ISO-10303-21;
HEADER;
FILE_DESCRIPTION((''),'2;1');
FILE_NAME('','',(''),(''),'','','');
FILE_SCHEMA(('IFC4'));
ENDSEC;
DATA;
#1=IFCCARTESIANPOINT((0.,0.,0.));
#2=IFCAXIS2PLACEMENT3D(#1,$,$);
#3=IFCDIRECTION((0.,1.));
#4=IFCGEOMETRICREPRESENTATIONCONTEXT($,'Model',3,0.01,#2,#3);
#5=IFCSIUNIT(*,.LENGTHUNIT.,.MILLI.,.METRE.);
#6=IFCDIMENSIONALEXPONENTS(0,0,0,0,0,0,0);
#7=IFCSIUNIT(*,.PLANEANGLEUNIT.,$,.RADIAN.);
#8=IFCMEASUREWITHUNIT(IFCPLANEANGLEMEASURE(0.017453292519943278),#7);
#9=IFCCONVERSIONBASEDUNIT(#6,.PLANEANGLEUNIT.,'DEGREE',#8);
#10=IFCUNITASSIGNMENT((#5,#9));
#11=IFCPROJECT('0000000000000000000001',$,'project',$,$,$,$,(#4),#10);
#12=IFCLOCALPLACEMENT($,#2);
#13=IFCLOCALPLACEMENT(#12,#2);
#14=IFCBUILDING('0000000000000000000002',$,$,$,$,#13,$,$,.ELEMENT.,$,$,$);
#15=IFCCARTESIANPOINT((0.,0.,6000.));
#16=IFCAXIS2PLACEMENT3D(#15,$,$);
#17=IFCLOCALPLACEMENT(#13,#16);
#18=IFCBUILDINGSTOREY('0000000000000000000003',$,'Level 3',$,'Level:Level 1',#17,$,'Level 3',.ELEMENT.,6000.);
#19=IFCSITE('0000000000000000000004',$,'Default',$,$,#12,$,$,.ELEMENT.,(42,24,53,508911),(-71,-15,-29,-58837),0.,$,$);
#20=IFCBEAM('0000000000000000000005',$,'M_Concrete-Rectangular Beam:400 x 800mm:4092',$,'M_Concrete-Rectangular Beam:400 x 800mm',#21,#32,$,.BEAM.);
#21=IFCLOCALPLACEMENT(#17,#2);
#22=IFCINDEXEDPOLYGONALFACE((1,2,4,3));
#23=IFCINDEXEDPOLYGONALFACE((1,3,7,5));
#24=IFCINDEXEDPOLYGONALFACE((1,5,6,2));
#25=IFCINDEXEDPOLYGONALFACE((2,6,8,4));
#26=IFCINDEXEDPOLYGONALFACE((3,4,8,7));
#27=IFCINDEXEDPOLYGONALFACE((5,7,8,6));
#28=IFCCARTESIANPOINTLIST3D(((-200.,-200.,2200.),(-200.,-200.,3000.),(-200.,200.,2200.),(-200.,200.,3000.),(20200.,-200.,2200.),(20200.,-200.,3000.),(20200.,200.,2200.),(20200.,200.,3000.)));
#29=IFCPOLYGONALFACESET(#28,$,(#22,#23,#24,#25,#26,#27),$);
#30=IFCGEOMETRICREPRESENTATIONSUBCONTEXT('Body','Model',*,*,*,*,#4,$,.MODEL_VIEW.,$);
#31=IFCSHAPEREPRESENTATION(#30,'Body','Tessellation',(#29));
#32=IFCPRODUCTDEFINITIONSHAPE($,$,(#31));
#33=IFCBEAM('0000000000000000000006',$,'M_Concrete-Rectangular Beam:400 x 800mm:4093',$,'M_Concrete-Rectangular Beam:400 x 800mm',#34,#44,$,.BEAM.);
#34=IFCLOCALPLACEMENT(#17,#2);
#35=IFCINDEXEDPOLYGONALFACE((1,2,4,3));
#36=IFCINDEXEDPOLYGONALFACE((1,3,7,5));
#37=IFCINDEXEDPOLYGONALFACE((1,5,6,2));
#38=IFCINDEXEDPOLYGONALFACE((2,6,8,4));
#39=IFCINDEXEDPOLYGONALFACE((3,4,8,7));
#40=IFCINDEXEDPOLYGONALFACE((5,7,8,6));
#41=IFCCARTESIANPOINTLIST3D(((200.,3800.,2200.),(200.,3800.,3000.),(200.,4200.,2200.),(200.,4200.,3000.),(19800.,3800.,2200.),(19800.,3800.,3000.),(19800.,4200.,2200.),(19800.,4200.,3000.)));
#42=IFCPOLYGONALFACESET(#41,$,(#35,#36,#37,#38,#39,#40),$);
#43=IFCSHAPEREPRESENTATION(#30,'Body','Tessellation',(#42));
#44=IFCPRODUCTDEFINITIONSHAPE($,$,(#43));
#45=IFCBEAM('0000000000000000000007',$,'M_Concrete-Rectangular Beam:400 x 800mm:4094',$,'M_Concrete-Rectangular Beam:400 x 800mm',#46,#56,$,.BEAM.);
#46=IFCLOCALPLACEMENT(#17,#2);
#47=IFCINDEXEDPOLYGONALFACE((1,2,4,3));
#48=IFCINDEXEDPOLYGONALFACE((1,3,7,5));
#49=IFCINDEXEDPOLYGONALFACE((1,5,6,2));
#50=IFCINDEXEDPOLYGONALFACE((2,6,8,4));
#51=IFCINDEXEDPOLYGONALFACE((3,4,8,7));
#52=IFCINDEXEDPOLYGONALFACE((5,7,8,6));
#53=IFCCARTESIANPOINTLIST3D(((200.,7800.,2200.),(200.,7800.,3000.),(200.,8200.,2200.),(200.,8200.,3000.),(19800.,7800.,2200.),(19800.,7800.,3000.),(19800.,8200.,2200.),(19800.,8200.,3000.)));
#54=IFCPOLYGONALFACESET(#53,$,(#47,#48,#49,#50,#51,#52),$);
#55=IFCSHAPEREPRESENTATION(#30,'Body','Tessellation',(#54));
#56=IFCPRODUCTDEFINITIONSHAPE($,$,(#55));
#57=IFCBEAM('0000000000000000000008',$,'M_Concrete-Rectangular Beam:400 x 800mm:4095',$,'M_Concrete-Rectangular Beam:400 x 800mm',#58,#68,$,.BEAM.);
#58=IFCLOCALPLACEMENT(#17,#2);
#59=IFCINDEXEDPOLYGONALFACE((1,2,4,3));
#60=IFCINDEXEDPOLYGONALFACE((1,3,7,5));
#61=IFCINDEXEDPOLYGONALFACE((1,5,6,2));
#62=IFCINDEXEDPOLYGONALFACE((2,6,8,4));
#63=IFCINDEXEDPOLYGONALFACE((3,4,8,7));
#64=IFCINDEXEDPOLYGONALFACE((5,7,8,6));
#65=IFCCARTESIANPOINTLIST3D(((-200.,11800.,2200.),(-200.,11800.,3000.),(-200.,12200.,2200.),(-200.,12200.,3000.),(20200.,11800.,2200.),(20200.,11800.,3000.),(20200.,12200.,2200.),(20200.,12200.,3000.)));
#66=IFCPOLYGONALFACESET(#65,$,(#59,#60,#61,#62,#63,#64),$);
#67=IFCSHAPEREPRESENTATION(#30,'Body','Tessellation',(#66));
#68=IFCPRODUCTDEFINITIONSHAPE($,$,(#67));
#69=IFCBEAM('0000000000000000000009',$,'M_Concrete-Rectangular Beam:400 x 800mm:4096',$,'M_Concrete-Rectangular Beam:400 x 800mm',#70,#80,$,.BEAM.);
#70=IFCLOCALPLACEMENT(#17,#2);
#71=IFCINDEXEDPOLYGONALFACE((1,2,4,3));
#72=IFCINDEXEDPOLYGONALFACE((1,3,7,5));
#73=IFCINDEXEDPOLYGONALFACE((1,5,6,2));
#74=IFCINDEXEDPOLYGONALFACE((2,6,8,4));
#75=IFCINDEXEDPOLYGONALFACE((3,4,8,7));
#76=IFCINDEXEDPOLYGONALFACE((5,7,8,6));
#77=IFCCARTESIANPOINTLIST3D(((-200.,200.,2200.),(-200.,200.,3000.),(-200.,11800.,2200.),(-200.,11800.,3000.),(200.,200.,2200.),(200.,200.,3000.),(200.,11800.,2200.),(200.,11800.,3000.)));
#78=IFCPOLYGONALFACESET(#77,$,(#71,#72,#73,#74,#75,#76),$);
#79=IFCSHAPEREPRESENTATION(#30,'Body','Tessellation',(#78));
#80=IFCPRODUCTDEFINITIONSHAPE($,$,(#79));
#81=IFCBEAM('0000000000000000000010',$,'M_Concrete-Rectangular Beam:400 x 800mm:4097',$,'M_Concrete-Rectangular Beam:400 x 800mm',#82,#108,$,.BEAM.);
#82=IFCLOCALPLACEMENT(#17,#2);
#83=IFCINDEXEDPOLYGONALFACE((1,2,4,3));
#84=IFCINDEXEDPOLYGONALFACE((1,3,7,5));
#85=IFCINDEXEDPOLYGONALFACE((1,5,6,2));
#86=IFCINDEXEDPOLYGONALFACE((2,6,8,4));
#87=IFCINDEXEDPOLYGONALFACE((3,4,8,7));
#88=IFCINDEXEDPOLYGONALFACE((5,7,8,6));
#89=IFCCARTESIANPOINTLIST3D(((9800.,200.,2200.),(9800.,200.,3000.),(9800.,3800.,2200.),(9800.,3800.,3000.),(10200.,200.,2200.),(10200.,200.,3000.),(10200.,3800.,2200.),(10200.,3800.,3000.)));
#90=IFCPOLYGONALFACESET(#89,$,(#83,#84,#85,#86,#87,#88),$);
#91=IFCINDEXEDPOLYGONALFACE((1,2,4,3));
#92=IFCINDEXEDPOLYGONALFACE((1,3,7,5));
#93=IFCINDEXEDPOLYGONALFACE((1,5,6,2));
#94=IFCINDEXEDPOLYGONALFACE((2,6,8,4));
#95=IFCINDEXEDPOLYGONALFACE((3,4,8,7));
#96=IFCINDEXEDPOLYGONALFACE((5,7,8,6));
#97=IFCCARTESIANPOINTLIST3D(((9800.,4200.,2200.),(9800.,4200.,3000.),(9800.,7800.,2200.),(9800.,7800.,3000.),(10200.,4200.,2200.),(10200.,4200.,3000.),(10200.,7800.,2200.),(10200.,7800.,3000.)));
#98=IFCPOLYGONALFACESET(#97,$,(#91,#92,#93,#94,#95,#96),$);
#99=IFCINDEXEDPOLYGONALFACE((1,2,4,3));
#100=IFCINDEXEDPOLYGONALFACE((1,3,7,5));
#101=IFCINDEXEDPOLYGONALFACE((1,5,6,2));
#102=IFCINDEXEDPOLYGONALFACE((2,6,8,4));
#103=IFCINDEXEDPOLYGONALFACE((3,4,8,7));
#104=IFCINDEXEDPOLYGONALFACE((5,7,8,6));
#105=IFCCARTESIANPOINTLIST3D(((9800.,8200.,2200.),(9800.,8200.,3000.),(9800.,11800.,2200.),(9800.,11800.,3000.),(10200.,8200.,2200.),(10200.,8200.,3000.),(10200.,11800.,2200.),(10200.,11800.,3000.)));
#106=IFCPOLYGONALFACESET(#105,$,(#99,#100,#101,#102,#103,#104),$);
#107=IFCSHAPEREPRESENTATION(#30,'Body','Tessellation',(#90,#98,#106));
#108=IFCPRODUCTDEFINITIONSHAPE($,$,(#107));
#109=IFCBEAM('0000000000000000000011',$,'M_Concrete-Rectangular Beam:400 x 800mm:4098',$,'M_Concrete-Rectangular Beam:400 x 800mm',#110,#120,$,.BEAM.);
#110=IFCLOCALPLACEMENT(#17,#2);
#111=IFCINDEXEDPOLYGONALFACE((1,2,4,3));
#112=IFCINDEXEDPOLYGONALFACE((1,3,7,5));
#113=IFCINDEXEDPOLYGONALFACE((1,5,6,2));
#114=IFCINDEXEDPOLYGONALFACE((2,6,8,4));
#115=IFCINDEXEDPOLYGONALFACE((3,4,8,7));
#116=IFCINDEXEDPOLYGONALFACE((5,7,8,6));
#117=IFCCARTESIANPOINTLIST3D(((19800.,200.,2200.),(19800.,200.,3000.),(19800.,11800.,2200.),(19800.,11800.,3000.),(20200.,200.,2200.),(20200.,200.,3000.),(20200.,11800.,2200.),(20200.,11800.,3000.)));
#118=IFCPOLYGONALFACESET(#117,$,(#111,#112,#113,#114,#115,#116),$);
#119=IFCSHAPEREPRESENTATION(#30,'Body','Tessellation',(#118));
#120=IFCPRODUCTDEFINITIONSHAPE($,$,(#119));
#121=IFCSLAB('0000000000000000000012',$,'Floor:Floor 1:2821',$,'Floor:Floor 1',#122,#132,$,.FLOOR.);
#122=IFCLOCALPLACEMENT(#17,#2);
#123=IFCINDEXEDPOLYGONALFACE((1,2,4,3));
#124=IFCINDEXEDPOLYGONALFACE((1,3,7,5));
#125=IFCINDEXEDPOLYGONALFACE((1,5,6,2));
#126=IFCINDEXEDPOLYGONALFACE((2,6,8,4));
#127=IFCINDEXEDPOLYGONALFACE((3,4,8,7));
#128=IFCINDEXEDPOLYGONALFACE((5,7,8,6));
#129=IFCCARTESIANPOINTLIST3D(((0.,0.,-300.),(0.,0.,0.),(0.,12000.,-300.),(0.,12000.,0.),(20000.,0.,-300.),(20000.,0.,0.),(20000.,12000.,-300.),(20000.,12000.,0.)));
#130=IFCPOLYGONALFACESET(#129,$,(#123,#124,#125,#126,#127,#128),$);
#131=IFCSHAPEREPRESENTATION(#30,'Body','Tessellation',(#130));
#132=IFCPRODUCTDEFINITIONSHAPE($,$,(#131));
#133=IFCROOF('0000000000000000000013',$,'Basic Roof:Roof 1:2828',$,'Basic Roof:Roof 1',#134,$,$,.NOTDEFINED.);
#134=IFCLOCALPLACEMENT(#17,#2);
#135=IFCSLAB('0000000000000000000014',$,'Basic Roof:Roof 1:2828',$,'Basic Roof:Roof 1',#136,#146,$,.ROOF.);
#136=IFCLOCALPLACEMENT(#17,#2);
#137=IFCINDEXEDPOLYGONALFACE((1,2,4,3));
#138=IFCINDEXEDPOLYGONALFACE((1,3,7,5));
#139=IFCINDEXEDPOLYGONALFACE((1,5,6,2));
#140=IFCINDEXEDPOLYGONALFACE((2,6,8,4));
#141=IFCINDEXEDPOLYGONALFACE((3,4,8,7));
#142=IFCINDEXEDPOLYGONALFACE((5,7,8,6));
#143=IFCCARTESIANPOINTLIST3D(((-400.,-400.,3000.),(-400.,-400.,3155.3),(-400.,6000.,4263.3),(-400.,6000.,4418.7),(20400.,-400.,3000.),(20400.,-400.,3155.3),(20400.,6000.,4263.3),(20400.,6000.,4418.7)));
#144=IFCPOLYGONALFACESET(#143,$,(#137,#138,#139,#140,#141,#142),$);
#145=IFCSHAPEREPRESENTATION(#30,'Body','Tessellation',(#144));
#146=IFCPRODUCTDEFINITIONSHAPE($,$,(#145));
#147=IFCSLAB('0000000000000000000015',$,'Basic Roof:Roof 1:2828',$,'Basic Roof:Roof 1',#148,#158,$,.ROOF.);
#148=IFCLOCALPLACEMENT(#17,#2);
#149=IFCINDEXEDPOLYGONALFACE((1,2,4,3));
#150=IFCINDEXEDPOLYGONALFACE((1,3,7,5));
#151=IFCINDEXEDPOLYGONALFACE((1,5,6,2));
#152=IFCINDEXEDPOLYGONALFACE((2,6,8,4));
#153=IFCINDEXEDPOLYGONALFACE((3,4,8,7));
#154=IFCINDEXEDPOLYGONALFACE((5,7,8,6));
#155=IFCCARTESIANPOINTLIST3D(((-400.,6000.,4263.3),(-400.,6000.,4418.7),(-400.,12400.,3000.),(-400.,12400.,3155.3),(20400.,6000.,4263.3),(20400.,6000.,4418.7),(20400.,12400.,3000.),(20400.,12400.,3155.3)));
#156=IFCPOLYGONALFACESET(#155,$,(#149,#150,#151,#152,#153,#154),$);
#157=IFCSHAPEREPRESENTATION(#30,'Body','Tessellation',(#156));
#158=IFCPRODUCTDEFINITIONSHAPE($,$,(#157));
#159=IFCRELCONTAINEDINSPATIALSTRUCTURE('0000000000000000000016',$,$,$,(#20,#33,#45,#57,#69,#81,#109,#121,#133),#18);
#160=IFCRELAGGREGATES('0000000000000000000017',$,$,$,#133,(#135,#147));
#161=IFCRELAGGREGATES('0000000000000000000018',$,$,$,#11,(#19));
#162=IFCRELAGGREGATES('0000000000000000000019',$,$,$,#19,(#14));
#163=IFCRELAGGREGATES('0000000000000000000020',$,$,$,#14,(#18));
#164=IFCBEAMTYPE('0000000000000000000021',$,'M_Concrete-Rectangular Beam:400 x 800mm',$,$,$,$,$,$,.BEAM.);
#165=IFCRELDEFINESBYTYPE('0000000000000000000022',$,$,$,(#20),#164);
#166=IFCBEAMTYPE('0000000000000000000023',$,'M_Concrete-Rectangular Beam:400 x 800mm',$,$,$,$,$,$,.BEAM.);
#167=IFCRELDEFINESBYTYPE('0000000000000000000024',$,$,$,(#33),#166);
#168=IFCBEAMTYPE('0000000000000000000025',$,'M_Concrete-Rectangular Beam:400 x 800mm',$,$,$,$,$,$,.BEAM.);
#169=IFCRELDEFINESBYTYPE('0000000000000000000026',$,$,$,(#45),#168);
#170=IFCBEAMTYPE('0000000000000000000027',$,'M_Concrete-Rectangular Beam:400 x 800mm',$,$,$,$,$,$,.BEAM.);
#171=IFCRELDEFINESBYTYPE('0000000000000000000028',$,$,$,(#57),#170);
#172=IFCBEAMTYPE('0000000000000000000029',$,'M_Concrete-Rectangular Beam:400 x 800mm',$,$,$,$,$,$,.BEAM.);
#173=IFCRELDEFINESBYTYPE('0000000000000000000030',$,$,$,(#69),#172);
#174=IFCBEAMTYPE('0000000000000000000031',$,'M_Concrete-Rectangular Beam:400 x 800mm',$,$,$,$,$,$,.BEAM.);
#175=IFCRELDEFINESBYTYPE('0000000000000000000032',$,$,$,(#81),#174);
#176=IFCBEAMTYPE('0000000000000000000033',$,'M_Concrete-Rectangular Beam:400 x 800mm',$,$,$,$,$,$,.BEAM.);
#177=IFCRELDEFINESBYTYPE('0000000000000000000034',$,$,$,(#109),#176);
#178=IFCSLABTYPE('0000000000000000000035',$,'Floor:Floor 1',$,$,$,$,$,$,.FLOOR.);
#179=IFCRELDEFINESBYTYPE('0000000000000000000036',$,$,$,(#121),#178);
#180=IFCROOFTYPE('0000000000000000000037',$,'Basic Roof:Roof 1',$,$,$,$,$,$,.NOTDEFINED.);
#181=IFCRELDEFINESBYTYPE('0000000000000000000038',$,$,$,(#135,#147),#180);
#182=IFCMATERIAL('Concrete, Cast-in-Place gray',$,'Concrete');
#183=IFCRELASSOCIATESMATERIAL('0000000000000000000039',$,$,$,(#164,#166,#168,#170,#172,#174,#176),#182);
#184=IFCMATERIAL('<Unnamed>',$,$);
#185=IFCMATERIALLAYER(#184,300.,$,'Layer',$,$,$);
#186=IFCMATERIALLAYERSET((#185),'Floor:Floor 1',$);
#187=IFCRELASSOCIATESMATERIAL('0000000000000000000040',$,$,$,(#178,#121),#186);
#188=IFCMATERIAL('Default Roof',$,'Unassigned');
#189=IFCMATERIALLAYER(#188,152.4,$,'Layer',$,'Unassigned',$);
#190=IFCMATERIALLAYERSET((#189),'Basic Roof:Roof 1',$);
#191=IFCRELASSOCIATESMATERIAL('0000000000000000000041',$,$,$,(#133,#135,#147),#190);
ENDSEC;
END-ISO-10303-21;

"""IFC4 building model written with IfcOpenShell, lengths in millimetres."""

from ifc_helpers import new_model, entity, si_unit, converted_unit, direction, frame, frame_2d, origin, origin_2d_with_axis, place, context, subcontext, project, spatial, rectangle, extrude, source, transform, mapped, material, layer, layer_set, layer_usage, material_profile, profile_set, type_object, type_shapes, element, aggregate, save


model = new_model("IFC4")

# Units and contexts
model_context = context("Model", 3, precision=0.01, world=origin(), true_north=direction((0.0, 1.0)))
body_context = subcontext(model_context, "Body", "Model", "MODEL_VIEW")
ifc_project = project(units=[si_unit("LENGTHUNIT", "METRE", prefix="MILLI"), converted_unit("PLANEANGLEUNIT", "DEGREE", entity("IfcPlaneAngleMeasure", 0.017453292519943278), si_unit("PLANEANGLEUNIT", "RADIAN"), dimensions=[0, 0, 0, 0, 0, 0, 0])], contexts=[model_context])

# Site, building, storey
site_placement = place(None, origin())
site = spatial("IfcSite", under=ifc_project, at=site_placement, Name="Default", CompositionType="ELEMENT", RefLatitude=(42, 24, 53, 508911), RefLongitude=(-71, -15, -29, -58837), RefElevation=0.0)
building_placement = place(site_placement, origin())
building = spatial("IfcBuilding", under=site, at=building_placement, CompositionType="ELEMENT")
storey_placement = place(building_placement, frame((0.0, 0.0, 6000.0)))
storey = spatial("IfcBuildingStorey", under=building, at=storey_placement, Name="Level 3", ObjectType="Level:Level 1", LongName="Level 3", CompositionType="ELEMENT", Elevation=6000.0)

# Beams
ifc_material_1 = material(Name="Concrete, Cast-in-Place gray", Category="Concrete")
ifc_material_profile = material_profile(ifc_material_1, rectangle(XDim=800.0, YDim=400.0, at=origin_2d_with_axis()), Name="400 x 800mm")
ifc_profile_set = profile_set([ifc_material_profile], Name="400 x 800mm")
beam_type_1 = type_object("IfcBeamType", Name="M_Concrete-Rectangular Beam:400 x 800mm", PredefinedType="BEAM", material=ifc_profile_set)
shared_shape_1 = source(origin(), body_context, "Body", "SweptSolid", [
    extrude(rectangle(XDim=800.0, YDim=400.0, at=origin_2d_with_axis()), frame((-200.0, 0.0, 8600.0), z_axis=(1.0, 0.0, 0.0), x_axis=(0.0, 0.0, -1.0)), (0.0, 0.0, 1.0), 20400.0),
])
type_shapes(beam_type_1, [shared_shape_1])
beam_1_placement = place(storey_placement, frame((0.0, 0.0, -6000.0)))
element("IfcBeam", 1, at=beam_1_placement, inside=storey, type_object=beam_type_1, Name="M_Concrete-Rectangular Beam:400 x 800mm:4092", ObjectType="M_Concrete-Rectangular Beam:400 x 800mm", PredefinedType="BEAM", context=body_context, shape_type="MappedRepresentation", body=[
    mapped(shared_shape_1, transform((0.0, 0.0, 0.0), scale=1.0)),
])
beam_type_2 = type_object("IfcBeamType", Name="M_Concrete-Rectangular Beam:400 x 800mm", PredefinedType="BEAM", material=ifc_profile_set)
shared_shape_2 = source(origin(), body_context, "Body", "SweptSolid", [
    extrude(rectangle(XDim=800.0, YDim=400.0, at=origin_2d_with_axis()), frame((200.0, 4000.0, 8600.0), z_axis=(1.0, 0.0, 0.0), x_axis=(0.0, 0.0, -1.0)), (0.0, 0.0, 1.0), 19600.0),
])
type_shapes(beam_type_2, [shared_shape_2])
beam_2_placement = place(storey_placement, frame((0.0, 0.0, -6000.0)))
element("IfcBeam", 2, at=beam_2_placement, inside=storey, type_object=beam_type_2, Name="M_Concrete-Rectangular Beam:400 x 800mm:4093", ObjectType="M_Concrete-Rectangular Beam:400 x 800mm", PredefinedType="BEAM", context=body_context, shape_type="MappedRepresentation", body=[
    mapped(shared_shape_2, transform((0.0, 0.0, 0.0), scale=1.0)),
])
beam_type_3 = type_object("IfcBeamType", Name="M_Concrete-Rectangular Beam:400 x 800mm", PredefinedType="BEAM", material=ifc_profile_set)
shared_shape_3 = source(origin(), body_context, "Body", "SweptSolid", [
    extrude(rectangle(XDim=800.0, YDim=400.0, at=frame_2d((0.0, 0.0), x_axis=(1.0, 0.0))), frame((200.0, 8000.0, 8600.0), z_axis=(1.0, 0.0, 0.0), x_axis=(0.0, 0.0, -1.0)), (0.0, 0.0, 1.0), 19600.0),
])
type_shapes(beam_type_3, [shared_shape_3])
beam_3_placement = place(storey_placement, frame((0.0, 0.0, -6000.0)))
element("IfcBeam", 3, at=beam_3_placement, inside=storey, type_object=beam_type_3, Name="M_Concrete-Rectangular Beam:400 x 800mm:4094", ObjectType="M_Concrete-Rectangular Beam:400 x 800mm", PredefinedType="BEAM", context=body_context, shape_type="MappedRepresentation", body=[
    mapped(shared_shape_3, transform((0.0, 0.0, 0.0), scale=1.0)),
])
beam_type_4 = type_object("IfcBeamType", Name="M_Concrete-Rectangular Beam:400 x 800mm", PredefinedType="BEAM", material=ifc_profile_set)
shared_shape_4 = source(origin(), body_context, "Body", "SweptSolid", [
    extrude(rectangle(XDim=800.0, YDim=400.0, at=frame_2d((0.0, 0.0), x_axis=(1.0, 0.0))), frame((-200.0, 12000.0, 8600.0), z_axis=(1.0, 0.0, 0.0), x_axis=(0.0, 0.0, -1.0)), (0.0, 0.0, 1.0), 20400.0),
])
type_shapes(beam_type_4, [shared_shape_4])
beam_4_placement = place(storey_placement, frame((0.0, 0.0, -6000.0)))
element("IfcBeam", 4, at=beam_4_placement, inside=storey, type_object=beam_type_4, Name="M_Concrete-Rectangular Beam:400 x 800mm:4095", ObjectType="M_Concrete-Rectangular Beam:400 x 800mm", PredefinedType="BEAM", context=body_context, shape_type="MappedRepresentation", body=[
    mapped(shared_shape_4, transform((0.0, 0.0, 0.0), scale=1.0)),
])
beam_type_5 = type_object("IfcBeamType", Name="M_Concrete-Rectangular Beam:400 x 800mm", PredefinedType="BEAM", material=ifc_profile_set)
shared_shape_5 = source(origin(), body_context, "Body", "SweptSolid", [
    extrude(rectangle(XDim=800.0, YDim=400.0, at=frame_2d((0.0, 0.0), x_axis=(0.0, 1.0))), frame((0.0, 200.0, 8600.0), z_axis=(0.0, 1.0, 0.0), x_axis=(-1.0, 0.0, 0.0)), (0.0, 0.0, 1.0), 11600.0),
])
type_shapes(beam_type_5, [shared_shape_5])
beam_5_placement = place(storey_placement, frame((0.0, 0.0, -6000.0)))
element("IfcBeam", 5, at=beam_5_placement, inside=storey, type_object=beam_type_5, Name="M_Concrete-Rectangular Beam:400 x 800mm:4096", ObjectType="M_Concrete-Rectangular Beam:400 x 800mm", PredefinedType="BEAM", context=body_context, shape_type="MappedRepresentation", body=[
    mapped(shared_shape_5, transform((0.0, 0.0, 0.0), scale=1.0)),
])
beam_type_6 = type_object("IfcBeamType", Name="M_Concrete-Rectangular Beam:400 x 800mm", PredefinedType="BEAM", material=ifc_profile_set)
shared_shape_6 = source(origin(), body_context, "Body", "SweptSolid", [
    extrude(rectangle(XDim=800.0, YDim=400.0, at=frame_2d((0.0, 0.0), x_axis=(0.0, 1.0))), frame((10000.0, 200.0, 8600.0), z_axis=(0.0, 1.0, 0.0), x_axis=(-1.0, 0.0, 0.0)), (0.0, 0.0, 1.0), 3600.0),
    extrude(rectangle(XDim=800.0, YDim=400.0, at=frame_2d((0.0, 0.0), x_axis=(0.0, 1.0))), frame((10000.0, 4200.0, 8600.0), z_axis=(0.0, 1.0, 0.0), x_axis=(-1.0, 0.0, 0.0)), (0.0, 0.0, 1.0), 3600.0),
    extrude(rectangle(XDim=800.0, YDim=400.0, at=frame_2d((0.0, 0.0), x_axis=(0.0, 1.0))), frame((10000.0, 8200.0, 8600.0), z_axis=(0.0, 1.0, 0.0), x_axis=(-1.0, 0.0, 0.0)), (0.0, 0.0, 1.0), 3600.0),
])
type_shapes(beam_type_6, [shared_shape_6])
beam_6_placement = place(storey_placement, frame((0.0, 0.0, -6000.0)))
element("IfcBeam", 6, at=beam_6_placement, inside=storey, type_object=beam_type_6, Name="M_Concrete-Rectangular Beam:400 x 800mm:4097", ObjectType="M_Concrete-Rectangular Beam:400 x 800mm", PredefinedType="BEAM", context=body_context, shape_type="MappedRepresentation", body=[
    mapped(shared_shape_6, transform((0.0, 0.0, 0.0), scale=1.0)),
])
beam_type_7 = type_object("IfcBeamType", Name="M_Concrete-Rectangular Beam:400 x 800mm", PredefinedType="BEAM", material=ifc_profile_set)
shared_shape_7 = source(origin(), body_context, "Body", "SweptSolid", [
    extrude(rectangle(XDim=800.0, YDim=400.0, at=frame_2d((0.0, 0.0), x_axis=(0.0, 1.0))), frame((20000.0, 200.0, 8600.0), z_axis=(0.0, 1.0, 0.0), x_axis=(-1.0, 0.0, 0.0)), (0.0, 0.0, 1.0), 11600.0),
])
type_shapes(beam_type_7, [shared_shape_7])
beam_7_placement = place(storey_placement, frame((0.0, 0.0, -6000.0)))
element("IfcBeam", 7, at=beam_7_placement, inside=storey, type_object=beam_type_7, Name="M_Concrete-Rectangular Beam:400 x 800mm:4098", ObjectType="M_Concrete-Rectangular Beam:400 x 800mm", PredefinedType="BEAM", context=body_context, shape_type="MappedRepresentation", body=[
    mapped(shared_shape_7, transform((0.0, 0.0, 0.0), scale=1.0)),
])

# Slab
ifc_material_2 = material(Name="<Unnamed>")
ifc_layer_1 = layer(ifc_material_2, 300.0, Name="Layer")
ifc_layer_set_1 = layer_set([ifc_layer_1], Name="Floor:Floor 1")
ifc_layer_usage_1 = layer_usage(ifc_layer_set_1, "AXIS3", "POSITIVE", 0.0)
slab_type = type_object("IfcSlabType", Name="Floor:Floor 1", PredefinedType="FLOOR", material=ifc_layer_set_1)
slab_1_placement = place(storey_placement, origin())
element("IfcSlab", 8, at=slab_1_placement, inside=storey, type_object=slab_type, material=ifc_layer_usage_1, Name="Floor:Floor 1:2821", ObjectType="Floor:Floor 1", PredefinedType="FLOOR", context=body_context, shape_type="SweptSolid", body=[
    extrude(rectangle(XDim=12000.0, YDim=20000.0, at=origin_2d_with_axis()), frame((10000.0, 6000.0, 0.0), z_axis=(0.0, 0.0, -1.0), x_axis=(0.0, 1.0, 0.0)), (0.0, 0.0, 1.0), 300.0),
])

# Roof, slabs
ifc_material_3 = material(Name="Default Roof", Category="Unassigned")
ifc_layer_2 = layer(ifc_material_3, 152.4, Name="Layer", Category="Unassigned")
ifc_layer_set_2 = layer_set([ifc_layer_2], Name="Basic Roof:Roof 1")
roof_placement = place(storey_placement, frame((-400.0, -400.0, 3000.0)))
roof = element("IfcRoof", 9, at=roof_placement, inside=storey, material=ifc_layer_set_2, Name="Basic Roof:Roof 1:2828", ObjectType="Basic Roof:Roof 1", PredefinedType="NOTDEFINED")
roof_type = type_object("IfcRoofType", Name="Basic Roof:Roof 1", PredefinedType="NOTDEFINED")
slab_2_placement = place(roof_placement, origin())
slab_2 = element("IfcSlab", 10, at=slab_2_placement, type_object=roof_type, material=ifc_layer_set_2, Name="Basic Roof:Roof 1:2828", ObjectType="Basic Roof:Roof 1", PredefinedType="ROOF", context=body_context, shape_type="SweptSolid", body=[
    extrude(rectangle(XDim=20800.0, YDim=6523.5, at=frame_2d((0.0, 0.0), x_axis=(-1.0, 0.0))), frame((10400.0, 3200.0, 631.7), z_axis=(0.0, -0.193659, 0.981069), x_axis=(1.0, 0.0, 0.0)), (0.0, 0.193659, 0.981069), 155.3),
])
slab_3_placement = place(roof_placement, origin())
slab_3 = element("IfcSlab", 11, at=slab_3_placement, type_object=roof_type, material=ifc_layer_set_2, Name="Basic Roof:Roof 1:2828", ObjectType="Basic Roof:Roof 1", PredefinedType="ROOF", context=body_context, shape_type="SweptSolid", body=[
    extrude(rectangle(XDim=6523.5, YDim=20800.0, at=frame_2d((0.0, 0.0), x_axis=(0.0, -1.0))), frame((10400.0, 9600.0, 631.7), z_axis=(0.0, 0.193659, 0.981069), x_axis=(1.0, 0.0, 0.0)), (0.0, -0.193659, 0.981069), 155.3),
])
aggregate(roof, [slab_2, slab_3])

save(model, "model.ifc")
